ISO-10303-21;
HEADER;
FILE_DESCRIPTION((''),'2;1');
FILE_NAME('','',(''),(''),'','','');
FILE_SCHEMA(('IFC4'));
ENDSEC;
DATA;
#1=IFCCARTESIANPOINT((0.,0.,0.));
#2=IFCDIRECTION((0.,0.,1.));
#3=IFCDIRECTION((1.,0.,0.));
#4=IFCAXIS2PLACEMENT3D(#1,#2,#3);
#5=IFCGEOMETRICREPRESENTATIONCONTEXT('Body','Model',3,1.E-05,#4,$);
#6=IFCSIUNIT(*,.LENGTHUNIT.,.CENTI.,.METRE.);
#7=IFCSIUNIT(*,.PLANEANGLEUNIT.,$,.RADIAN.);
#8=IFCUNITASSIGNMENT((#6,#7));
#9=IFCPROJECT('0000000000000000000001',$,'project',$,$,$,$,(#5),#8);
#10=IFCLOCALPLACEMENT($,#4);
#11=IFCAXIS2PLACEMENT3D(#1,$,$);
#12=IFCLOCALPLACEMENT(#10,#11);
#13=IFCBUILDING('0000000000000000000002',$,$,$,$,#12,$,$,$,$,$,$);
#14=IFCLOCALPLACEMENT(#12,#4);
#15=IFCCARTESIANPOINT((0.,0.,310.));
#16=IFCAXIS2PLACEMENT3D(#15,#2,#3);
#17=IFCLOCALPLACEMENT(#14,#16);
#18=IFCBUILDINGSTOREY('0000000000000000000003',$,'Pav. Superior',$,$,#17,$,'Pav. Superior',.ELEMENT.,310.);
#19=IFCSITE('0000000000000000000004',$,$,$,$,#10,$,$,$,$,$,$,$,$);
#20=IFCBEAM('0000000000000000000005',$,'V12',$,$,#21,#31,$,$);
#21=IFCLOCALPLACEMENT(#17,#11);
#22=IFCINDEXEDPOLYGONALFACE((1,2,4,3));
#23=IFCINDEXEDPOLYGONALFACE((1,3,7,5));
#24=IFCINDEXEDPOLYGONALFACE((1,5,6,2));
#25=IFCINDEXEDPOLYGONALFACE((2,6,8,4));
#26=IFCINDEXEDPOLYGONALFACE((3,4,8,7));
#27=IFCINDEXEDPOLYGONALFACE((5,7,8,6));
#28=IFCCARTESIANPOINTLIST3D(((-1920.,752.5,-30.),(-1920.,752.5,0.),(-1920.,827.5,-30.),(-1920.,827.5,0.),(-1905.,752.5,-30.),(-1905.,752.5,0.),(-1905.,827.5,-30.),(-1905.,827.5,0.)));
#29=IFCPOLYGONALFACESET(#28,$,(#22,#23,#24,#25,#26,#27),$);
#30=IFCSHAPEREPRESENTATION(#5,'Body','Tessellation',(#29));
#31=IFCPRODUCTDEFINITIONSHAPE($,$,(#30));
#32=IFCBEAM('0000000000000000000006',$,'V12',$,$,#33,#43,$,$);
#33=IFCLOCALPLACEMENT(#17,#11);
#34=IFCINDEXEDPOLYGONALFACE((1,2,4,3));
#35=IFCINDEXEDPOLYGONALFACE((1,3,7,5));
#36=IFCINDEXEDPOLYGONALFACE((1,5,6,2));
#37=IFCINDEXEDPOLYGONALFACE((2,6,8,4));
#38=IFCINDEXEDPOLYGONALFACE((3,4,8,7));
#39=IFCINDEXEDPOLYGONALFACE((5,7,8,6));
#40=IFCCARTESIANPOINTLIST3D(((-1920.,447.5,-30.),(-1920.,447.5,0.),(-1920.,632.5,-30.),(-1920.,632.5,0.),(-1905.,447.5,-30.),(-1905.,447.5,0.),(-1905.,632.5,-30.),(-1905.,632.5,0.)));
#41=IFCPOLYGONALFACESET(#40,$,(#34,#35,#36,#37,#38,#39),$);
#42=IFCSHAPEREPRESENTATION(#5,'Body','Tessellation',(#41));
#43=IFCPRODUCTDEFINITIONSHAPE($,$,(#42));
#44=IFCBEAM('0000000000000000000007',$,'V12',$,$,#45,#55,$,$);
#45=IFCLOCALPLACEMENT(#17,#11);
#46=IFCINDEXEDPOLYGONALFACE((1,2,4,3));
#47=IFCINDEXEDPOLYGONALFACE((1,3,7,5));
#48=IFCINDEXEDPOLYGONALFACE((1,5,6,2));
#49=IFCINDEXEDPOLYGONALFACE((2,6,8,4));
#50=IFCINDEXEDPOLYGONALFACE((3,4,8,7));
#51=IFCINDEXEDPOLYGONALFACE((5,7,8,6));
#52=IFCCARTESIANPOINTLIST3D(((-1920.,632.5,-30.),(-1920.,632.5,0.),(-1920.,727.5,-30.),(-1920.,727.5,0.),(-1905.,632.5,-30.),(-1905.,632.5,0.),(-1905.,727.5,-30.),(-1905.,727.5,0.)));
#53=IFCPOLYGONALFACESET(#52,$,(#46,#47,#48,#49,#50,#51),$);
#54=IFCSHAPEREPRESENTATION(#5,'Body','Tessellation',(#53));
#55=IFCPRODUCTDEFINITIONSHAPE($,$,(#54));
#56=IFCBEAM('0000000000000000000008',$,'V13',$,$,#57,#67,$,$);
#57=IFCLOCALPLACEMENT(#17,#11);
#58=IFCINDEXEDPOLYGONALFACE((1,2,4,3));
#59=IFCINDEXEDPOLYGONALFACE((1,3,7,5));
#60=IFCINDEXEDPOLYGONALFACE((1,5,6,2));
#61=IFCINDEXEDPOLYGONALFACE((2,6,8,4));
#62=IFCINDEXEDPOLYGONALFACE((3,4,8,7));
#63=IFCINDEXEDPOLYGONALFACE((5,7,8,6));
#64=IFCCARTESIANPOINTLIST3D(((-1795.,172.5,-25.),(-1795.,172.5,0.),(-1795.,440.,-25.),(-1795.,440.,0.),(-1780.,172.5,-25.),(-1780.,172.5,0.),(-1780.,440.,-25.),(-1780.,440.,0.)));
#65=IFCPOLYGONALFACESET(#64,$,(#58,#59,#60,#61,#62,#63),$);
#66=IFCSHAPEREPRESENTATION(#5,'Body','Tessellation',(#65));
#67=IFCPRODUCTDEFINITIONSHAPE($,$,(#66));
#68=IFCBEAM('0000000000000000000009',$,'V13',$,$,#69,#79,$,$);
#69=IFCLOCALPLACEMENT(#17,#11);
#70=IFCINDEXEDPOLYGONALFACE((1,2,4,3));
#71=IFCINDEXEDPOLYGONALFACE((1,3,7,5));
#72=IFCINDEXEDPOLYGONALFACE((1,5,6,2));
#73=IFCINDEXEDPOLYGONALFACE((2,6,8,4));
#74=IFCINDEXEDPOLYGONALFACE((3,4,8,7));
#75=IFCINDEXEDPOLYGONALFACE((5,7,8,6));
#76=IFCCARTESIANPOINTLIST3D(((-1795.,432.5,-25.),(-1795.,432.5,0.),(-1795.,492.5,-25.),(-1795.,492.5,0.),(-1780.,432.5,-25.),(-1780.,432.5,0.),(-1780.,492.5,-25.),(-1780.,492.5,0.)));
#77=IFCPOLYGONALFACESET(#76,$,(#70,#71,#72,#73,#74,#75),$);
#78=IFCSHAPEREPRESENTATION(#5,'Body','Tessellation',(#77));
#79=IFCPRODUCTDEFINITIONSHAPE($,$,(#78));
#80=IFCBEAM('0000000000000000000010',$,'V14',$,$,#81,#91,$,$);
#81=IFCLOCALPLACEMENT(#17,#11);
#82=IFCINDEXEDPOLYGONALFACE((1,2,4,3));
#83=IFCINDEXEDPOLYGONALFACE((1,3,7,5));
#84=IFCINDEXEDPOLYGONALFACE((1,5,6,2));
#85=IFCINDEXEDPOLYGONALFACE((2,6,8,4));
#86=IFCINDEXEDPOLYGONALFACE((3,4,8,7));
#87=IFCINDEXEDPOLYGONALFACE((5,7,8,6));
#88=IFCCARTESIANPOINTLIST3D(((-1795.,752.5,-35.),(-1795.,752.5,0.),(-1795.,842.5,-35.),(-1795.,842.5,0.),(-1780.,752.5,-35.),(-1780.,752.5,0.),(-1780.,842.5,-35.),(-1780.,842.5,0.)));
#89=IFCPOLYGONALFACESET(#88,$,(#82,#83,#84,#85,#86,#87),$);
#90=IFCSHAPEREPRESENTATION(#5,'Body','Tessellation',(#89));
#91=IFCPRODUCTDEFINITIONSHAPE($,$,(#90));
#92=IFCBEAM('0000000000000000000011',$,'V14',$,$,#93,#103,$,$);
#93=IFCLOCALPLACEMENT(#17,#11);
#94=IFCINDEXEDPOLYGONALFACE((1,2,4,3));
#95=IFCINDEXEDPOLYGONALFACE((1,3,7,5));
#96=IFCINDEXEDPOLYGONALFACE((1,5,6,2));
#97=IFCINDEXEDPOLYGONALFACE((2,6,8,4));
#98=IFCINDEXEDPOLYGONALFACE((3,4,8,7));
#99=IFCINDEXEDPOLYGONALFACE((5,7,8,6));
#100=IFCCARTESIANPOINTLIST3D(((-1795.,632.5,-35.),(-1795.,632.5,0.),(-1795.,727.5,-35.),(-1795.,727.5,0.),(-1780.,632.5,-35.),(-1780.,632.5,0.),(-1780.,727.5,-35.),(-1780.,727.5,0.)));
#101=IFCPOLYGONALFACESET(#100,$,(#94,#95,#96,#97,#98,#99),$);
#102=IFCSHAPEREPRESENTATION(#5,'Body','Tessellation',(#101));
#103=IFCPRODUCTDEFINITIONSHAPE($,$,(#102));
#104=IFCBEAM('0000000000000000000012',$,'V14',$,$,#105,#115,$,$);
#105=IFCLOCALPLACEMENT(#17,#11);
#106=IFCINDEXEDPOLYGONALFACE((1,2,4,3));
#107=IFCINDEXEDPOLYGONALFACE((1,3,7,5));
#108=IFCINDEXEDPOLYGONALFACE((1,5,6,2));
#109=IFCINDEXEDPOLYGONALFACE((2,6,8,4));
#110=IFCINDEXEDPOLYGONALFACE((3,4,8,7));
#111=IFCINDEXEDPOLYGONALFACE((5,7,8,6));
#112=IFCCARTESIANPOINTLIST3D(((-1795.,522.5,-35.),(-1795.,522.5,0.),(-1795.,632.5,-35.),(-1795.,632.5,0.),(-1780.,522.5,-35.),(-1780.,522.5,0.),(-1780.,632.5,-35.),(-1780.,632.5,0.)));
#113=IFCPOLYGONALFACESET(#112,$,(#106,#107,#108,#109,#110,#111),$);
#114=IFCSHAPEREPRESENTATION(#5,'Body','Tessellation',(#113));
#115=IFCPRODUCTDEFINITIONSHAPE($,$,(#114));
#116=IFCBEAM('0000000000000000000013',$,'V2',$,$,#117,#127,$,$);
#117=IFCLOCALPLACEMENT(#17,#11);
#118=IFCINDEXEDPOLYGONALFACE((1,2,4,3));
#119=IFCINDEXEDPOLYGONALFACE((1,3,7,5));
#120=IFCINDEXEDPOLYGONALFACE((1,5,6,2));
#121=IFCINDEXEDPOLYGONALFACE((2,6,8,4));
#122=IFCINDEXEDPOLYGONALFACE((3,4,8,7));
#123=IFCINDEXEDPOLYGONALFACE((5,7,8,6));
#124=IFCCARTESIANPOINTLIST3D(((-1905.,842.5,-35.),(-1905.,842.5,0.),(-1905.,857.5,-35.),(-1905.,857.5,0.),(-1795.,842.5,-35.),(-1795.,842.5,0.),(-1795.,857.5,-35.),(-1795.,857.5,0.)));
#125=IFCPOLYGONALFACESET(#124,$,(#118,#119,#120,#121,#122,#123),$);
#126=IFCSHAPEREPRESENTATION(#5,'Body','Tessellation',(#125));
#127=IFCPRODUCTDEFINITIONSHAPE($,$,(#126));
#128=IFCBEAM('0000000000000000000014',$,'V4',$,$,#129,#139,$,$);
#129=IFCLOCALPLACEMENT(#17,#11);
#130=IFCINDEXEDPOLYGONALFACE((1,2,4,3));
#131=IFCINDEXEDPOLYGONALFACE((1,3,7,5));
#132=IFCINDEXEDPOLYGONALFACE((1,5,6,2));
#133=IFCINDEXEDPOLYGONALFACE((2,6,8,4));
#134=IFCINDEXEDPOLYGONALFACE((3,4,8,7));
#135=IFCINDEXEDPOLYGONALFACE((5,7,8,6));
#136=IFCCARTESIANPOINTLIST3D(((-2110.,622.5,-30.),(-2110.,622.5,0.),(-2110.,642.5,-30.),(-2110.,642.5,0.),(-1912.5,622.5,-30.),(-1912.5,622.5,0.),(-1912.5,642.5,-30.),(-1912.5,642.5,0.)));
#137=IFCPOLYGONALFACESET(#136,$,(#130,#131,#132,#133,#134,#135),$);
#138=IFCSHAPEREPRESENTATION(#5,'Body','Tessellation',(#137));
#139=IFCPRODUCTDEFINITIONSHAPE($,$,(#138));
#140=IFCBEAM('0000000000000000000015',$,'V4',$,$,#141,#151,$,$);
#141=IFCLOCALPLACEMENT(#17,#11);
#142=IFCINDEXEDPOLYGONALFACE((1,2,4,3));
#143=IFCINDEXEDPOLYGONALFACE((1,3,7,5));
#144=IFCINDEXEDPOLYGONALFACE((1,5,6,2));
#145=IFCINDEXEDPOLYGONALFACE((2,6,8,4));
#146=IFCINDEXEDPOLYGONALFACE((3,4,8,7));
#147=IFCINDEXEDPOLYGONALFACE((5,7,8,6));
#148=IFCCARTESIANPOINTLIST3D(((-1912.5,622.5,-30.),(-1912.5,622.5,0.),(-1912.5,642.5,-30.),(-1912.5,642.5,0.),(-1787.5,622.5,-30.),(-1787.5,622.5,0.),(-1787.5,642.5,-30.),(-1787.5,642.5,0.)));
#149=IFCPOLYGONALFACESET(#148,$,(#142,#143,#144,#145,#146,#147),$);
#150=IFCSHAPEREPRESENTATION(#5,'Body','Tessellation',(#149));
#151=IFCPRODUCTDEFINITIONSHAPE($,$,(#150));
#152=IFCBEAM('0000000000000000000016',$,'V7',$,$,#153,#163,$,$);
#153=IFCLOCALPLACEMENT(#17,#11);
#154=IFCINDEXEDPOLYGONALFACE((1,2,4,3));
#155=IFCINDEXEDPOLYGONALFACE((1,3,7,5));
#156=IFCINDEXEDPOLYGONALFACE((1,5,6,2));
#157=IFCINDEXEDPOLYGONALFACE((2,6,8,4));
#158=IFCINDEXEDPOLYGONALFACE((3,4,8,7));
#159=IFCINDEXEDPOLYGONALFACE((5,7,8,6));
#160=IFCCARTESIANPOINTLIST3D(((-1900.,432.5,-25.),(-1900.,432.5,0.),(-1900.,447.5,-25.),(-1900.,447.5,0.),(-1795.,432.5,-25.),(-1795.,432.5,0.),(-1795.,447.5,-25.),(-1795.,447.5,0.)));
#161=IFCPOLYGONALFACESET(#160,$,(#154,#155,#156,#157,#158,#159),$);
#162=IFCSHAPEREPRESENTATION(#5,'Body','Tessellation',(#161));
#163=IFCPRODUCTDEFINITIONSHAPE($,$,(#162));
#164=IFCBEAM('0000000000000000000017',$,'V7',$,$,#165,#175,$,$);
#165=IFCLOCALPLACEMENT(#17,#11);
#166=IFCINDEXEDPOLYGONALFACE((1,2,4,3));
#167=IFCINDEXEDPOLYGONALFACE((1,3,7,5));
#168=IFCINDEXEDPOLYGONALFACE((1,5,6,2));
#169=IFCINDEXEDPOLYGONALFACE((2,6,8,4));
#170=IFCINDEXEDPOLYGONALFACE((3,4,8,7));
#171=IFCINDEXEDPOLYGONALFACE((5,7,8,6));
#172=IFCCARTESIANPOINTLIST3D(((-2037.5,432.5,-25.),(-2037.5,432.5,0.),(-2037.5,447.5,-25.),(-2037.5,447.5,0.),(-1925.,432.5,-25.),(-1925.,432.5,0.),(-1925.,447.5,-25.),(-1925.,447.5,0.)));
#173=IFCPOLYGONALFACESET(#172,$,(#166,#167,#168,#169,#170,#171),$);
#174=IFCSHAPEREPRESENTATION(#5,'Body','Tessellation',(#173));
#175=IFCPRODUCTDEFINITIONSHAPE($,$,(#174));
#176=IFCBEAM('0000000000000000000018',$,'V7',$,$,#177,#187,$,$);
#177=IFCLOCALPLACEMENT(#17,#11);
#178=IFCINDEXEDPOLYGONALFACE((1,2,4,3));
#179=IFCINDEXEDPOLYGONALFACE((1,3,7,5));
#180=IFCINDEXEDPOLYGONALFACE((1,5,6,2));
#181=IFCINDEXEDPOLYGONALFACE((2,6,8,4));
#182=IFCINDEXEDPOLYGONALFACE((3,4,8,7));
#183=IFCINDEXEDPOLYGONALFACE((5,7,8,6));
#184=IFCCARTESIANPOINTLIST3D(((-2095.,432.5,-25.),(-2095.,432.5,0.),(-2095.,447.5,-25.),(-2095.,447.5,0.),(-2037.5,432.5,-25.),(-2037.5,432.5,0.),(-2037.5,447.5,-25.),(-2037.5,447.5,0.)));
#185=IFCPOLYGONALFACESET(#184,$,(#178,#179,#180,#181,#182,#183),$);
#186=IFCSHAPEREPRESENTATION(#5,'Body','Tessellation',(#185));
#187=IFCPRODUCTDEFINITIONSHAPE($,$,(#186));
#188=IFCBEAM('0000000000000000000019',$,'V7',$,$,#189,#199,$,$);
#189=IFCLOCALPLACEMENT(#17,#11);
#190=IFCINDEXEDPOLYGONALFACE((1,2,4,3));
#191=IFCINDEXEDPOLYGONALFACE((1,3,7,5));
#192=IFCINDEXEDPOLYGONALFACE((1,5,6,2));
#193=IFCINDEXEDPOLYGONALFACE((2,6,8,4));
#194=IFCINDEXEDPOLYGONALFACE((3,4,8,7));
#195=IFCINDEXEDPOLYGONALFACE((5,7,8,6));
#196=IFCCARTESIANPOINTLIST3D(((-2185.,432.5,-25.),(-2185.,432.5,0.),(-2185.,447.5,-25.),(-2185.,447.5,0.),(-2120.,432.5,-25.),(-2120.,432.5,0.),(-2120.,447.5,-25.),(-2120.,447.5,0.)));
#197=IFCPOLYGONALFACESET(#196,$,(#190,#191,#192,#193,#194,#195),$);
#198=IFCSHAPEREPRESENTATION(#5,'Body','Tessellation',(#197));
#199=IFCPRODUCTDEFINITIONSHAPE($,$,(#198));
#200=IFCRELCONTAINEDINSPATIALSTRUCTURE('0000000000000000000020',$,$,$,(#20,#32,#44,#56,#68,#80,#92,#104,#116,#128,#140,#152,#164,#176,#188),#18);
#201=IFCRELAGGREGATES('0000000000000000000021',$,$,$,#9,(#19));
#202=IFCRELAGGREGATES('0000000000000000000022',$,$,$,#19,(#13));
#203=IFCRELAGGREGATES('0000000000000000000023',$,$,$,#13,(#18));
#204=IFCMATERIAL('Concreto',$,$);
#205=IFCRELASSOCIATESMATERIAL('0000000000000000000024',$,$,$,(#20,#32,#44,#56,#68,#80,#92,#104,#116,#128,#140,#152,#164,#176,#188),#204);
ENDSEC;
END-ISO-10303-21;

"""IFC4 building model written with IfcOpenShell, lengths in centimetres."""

from ifc_helpers import new_model, si_unit, frame, origin, origin_with_axes, origin_2d_with_axis, place, context, project, spatial, rectangle, extrude, material, element, save


model = new_model("IFC4")

# Units and contexts
model_context = context("Model", 3, precision=1e-05, world=origin_with_axes(), identifier="Body")
ifc_project = project(units=[si_unit("LENGTHUNIT", "METRE", prefix="CENTI"), si_unit("PLANEANGLEUNIT", "RADIAN")], contexts=[model_context])

# Site, building, storey
site_placement = place(None, origin_with_axes())
site = spatial("IfcSite", under=ifc_project, at=site_placement)
building_placement = place(site_placement, origin())
building = spatial("IfcBuilding", under=site, at=building_placement)
placement = place(building_placement, origin_with_axes())
storey_placement = place(placement, frame((0.0, 0.0, 310.0), z_axis=(0.0, 0.0, 1.0), x_axis=(1.0, 0.0, 0.0)))
storey = spatial("IfcBuildingStorey", under=building, at=storey_placement, Name="Pav. Superior", LongName="Pav. Superior", CompositionType="ELEMENT", Elevation=310.0)

# Shared definitions
ifc_material = material(Name="Concreto")

# Beams
beam_1_placement = place(storey_placement, frame((-1912.5, 790.0, 0.0), z_axis=(0.0, 0.0, 1.0), x_axis=(1.0, 0.0, 0.0)))
element("IfcBeam", 1, at=beam_1_placement, inside=storey, material=ifc_material, Name="V12", context=model_context, shape_type="SolidModel", body=[
    extrude(rectangle(XDim=15.0, YDim=30.0, at=origin_2d_with_axis()), frame((0.0, -37.5, -15.0), z_axis=(0.0, 1.0, 0.0), x_axis=(-1.0, 0.0, 0.0)), (0.0, 0.0, 1.0), 75.0),
])
beam_2_placement = place(storey_placement, frame((-1912.5, 540.0, 0.0), z_axis=(0.0, 0.0, 1.0), x_axis=(1.0, 0.0, 0.0)))
element("IfcBeam", 2, at=beam_2_placement, inside=storey, material=ifc_material, Name="V12", context=model_context, shape_type="SolidModel", body=[
    extrude(rectangle(XDim=15.0, YDim=30.0, at=origin_2d_with_axis()), frame((0.0, -92.5, -15.0), z_axis=(0.0, 1.0, 0.0), x_axis=(-1.0, 0.0, 0.0)), (0.0, 0.0, 1.0), 185.0),
])
beam_3_placement = place(storey_placement, frame((-1912.5, 680.0, 0.0), z_axis=(0.0, 0.0, 1.0), x_axis=(1.0, 0.0, 0.0)))
element("IfcBeam", 3, at=beam_3_placement, inside=storey, material=ifc_material, Name="V12", context=model_context, shape_type="SolidModel", body=[
    extrude(rectangle(XDim=15.0, YDim=30.0, at=origin_2d_with_axis()), frame((0.0, -47.5, -15.0), z_axis=(0.0, 1.0, 0.0), x_axis=(-1.0, 0.0, 0.0)), (0.0, 0.0, 1.0), 95.0),
])
beam_4_placement = place(storey_placement, frame((-1787.5, 306.25, 0.0), z_axis=(0.0, 0.0, 1.0), x_axis=(1.0, 0.0, 0.0)))
element("IfcBeam", 4, at=beam_4_placement, inside=storey, material=ifc_material, Name="V13", context=model_context, shape_type="SolidModel", body=[
    extrude(rectangle(XDim=15.0, YDim=25.0, at=origin_2d_with_axis()), frame((0.0, -133.75, -12.5), z_axis=(0.0, 1.0, 0.0), x_axis=(-1.0, 0.0, 0.0)), (0.0, 0.0, 1.0), 267.5),
])
beam_5_placement = place(storey_placement, frame((-1787.5, 462.5, 0.0), z_axis=(0.0, 0.0, 1.0), x_axis=(1.0, 0.0, 0.0)))
element("IfcBeam", 5, at=beam_5_placement, inside=storey, material=ifc_material, Name="V13", context=model_context, shape_type="SolidModel", body=[
    extrude(rectangle(XDim=15.0, YDim=25.0, at=origin_2d_with_axis()), frame((0.0, -30.0, -12.5), z_axis=(0.0, 1.0, 0.0), x_axis=(-1.0, 0.0, 0.0)), (0.0, 0.0, 1.0), 60.0),
])
beam_6_placement = place(storey_placement, frame((-1787.5, 797.5, 0.0), z_axis=(0.0, 0.0, 1.0), x_axis=(1.0, 0.0, 0.0)))
element("IfcBeam", 6, at=beam_6_placement, inside=storey, material=ifc_material, Name="V14", context=model_context, shape_type="SolidModel", body=[
    extrude(rectangle(XDim=15.0, YDim=35.0, at=origin_2d_with_axis()), frame((0.0, -45.0, -17.5), z_axis=(0.0, 1.0, 0.0), x_axis=(-1.0, 0.0, 0.0)), (0.0, 0.0, 1.0), 90.0),
])
beam_7_placement = place(storey_placement, frame((-1787.5, 680.0, 0.0), z_axis=(0.0, 0.0, 1.0), x_axis=(1.0, 0.0, 0.0)))
element("IfcBeam", 7, at=beam_7_placement, inside=storey, material=ifc_material, Name="V14", context=model_context, shape_type="SolidModel", body=[
    extrude(rectangle(XDim=15.0, YDim=35.0, at=origin_2d_with_axis()), frame((0.0, -47.5, -17.5), z_axis=(0.0, 1.0, 0.0), x_axis=(-1.0, 0.0, 0.0)), (0.0, 0.0, 1.0), 95.0),
])
beam_8_placement = place(storey_placement, frame((-1787.5, 577.5, 0.0), z_axis=(0.0, 0.0, 1.0), x_axis=(1.0, 0.0, 0.0)))
element("IfcBeam", 8, at=beam_8_placement, inside=storey, material=ifc_material, Name="V14", context=model_context, shape_type="SolidModel", body=[
    extrude(rectangle(XDim=15.0, YDim=35.0, at=origin_2d_with_axis()), frame((0.0, -55.0, -17.5), z_axis=(0.0, 1.0, 0.0), x_axis=(-1.0, 0.0, 0.0)), (0.0, 0.0, 1.0), 110.0),
])
beam_9_placement = place(storey_placement, frame((-1850.0, 850.0, 0.0), z_axis=(0.0, 0.0, 1.0), x_axis=(1.0, 0.0, 0.0)))
element("IfcBeam", 9, at=beam_9_placement, inside=storey, material=ifc_material, Name="V2", context=model_context, shape_type="SolidModel", body=[
    extrude(rectangle(XDim=15.0, YDim=35.0, at=origin_2d_with_axis()), frame((-55.0, 0.0, -17.5), z_axis=(1.0, 0.0, 0.0), x_axis=(0.0, -1.0, 0.0)), (0.0, 0.0, 1.0), 110.0),
])
beam_10_placement = place(storey_placement, frame((-2011.25, 632.5, 0.0), z_axis=(0.0, 0.0, 1.0), x_axis=(1.0, 0.0, 0.0)))
element("IfcBeam", 10, at=beam_10_placement, inside=storey, material=ifc_material, Name="V4", context=model_context, shape_type="SolidModel", body=[
    extrude(rectangle(XDim=20.0, YDim=30.0, at=origin_2d_with_axis()), frame((-98.75, 0.0, -15.0), z_axis=(1.0, 0.0, 0.0), x_axis=(0.0, -1.0, 0.0)), (0.0, 0.0, 1.0), 197.5),
])
beam_11_placement = place(storey_placement, frame((-1850.0, 632.5, 0.0), z_axis=(0.0, 0.0, 1.0), x_axis=(1.0, 0.0, 0.0)))
element("IfcBeam", 11, at=beam_11_placement, inside=storey, material=ifc_material, Name="V4", context=model_context, shape_type="SolidModel", body=[
    extrude(rectangle(XDim=20.0, YDim=30.0, at=origin_2d_with_axis()), frame((-62.5, 0.0, -15.0), z_axis=(1.0, 0.0, 0.0), x_axis=(0.0, -1.0, 0.0)), (0.0, 0.0, 1.0), 125.0),
])
beam_12_placement = place(storey_placement, frame((-1847.5, 440.0, 0.0), z_axis=(0.0, 0.0, 1.0), x_axis=(1.0, 0.0, 0.0)))
element("IfcBeam", 12, at=beam_12_placement, inside=storey, material=ifc_material, Name="V7", context=model_context, shape_type="SolidModel", body=[
    extrude(rectangle(XDim=15.0, YDim=25.0, at=origin_2d_with_axis()), frame((-52.5, 0.0, -12.5), z_axis=(1.0, 0.0, 0.0), x_axis=(0.0, -1.0, 0.0)), (0.0, 0.0, 1.0), 105.0),
])
beam_13_placement = place(storey_placement, frame((-1981.25, 440.0, 0.0), z_axis=(0.0, 0.0, 1.0), x_axis=(1.0, 0.0, 0.0)))
element("IfcBeam", 13, at=beam_13_placement, inside=storey, material=ifc_material, Name="V7", context=model_context, shape_type="SolidModel", body=[
    extrude(rectangle(XDim=15.0, YDim=25.0, at=origin_2d_with_axis()), frame((-56.25, 0.0, -12.5), z_axis=(1.0, 0.0, 0.0), x_axis=(0.0, -1.0, 0.0)), (0.0, 0.0, 1.0), 112.5),
])
beam_14_placement = place(storey_placement, frame((-2066.25, 440.0, 0.0), z_axis=(0.0, 0.0, 1.0), x_axis=(1.0, 0.0, 0.0)))
element("IfcBeam", 14, at=beam_14_placement, inside=storey, material=ifc_material, Name="V7", context=model_context, shape_type="SolidModel", body=[
    extrude(rectangle(XDim=15.0, YDim=25.0, at=origin_2d_with_axis()), frame((-28.75, 0.0, -12.5), z_axis=(1.0, 0.0, 0.0), x_axis=(0.0, -1.0, 0.0)), (0.0, 0.0, 1.0), 57.5),
])
beam_15_placement = place(storey_placement, frame((-2152.5, 440.0, 0.0), z_axis=(0.0, 0.0, 1.0), x_axis=(1.0, 0.0, 0.0)))
element("IfcBeam", 15, at=beam_15_placement, inside=storey, material=ifc_material, Name="V7", context=model_context, shape_type="SolidModel", body=[
    extrude(rectangle(XDim=15.0, YDim=25.0, at=origin_2d_with_axis()), frame((-32.5, 0.0, -12.5), z_axis=(1.0, 0.0, 0.0), x_axis=(0.0, -1.0, 0.0)), (0.0, 0.0, 1.0), 65.0),
])

save(model, "model.ifc")
